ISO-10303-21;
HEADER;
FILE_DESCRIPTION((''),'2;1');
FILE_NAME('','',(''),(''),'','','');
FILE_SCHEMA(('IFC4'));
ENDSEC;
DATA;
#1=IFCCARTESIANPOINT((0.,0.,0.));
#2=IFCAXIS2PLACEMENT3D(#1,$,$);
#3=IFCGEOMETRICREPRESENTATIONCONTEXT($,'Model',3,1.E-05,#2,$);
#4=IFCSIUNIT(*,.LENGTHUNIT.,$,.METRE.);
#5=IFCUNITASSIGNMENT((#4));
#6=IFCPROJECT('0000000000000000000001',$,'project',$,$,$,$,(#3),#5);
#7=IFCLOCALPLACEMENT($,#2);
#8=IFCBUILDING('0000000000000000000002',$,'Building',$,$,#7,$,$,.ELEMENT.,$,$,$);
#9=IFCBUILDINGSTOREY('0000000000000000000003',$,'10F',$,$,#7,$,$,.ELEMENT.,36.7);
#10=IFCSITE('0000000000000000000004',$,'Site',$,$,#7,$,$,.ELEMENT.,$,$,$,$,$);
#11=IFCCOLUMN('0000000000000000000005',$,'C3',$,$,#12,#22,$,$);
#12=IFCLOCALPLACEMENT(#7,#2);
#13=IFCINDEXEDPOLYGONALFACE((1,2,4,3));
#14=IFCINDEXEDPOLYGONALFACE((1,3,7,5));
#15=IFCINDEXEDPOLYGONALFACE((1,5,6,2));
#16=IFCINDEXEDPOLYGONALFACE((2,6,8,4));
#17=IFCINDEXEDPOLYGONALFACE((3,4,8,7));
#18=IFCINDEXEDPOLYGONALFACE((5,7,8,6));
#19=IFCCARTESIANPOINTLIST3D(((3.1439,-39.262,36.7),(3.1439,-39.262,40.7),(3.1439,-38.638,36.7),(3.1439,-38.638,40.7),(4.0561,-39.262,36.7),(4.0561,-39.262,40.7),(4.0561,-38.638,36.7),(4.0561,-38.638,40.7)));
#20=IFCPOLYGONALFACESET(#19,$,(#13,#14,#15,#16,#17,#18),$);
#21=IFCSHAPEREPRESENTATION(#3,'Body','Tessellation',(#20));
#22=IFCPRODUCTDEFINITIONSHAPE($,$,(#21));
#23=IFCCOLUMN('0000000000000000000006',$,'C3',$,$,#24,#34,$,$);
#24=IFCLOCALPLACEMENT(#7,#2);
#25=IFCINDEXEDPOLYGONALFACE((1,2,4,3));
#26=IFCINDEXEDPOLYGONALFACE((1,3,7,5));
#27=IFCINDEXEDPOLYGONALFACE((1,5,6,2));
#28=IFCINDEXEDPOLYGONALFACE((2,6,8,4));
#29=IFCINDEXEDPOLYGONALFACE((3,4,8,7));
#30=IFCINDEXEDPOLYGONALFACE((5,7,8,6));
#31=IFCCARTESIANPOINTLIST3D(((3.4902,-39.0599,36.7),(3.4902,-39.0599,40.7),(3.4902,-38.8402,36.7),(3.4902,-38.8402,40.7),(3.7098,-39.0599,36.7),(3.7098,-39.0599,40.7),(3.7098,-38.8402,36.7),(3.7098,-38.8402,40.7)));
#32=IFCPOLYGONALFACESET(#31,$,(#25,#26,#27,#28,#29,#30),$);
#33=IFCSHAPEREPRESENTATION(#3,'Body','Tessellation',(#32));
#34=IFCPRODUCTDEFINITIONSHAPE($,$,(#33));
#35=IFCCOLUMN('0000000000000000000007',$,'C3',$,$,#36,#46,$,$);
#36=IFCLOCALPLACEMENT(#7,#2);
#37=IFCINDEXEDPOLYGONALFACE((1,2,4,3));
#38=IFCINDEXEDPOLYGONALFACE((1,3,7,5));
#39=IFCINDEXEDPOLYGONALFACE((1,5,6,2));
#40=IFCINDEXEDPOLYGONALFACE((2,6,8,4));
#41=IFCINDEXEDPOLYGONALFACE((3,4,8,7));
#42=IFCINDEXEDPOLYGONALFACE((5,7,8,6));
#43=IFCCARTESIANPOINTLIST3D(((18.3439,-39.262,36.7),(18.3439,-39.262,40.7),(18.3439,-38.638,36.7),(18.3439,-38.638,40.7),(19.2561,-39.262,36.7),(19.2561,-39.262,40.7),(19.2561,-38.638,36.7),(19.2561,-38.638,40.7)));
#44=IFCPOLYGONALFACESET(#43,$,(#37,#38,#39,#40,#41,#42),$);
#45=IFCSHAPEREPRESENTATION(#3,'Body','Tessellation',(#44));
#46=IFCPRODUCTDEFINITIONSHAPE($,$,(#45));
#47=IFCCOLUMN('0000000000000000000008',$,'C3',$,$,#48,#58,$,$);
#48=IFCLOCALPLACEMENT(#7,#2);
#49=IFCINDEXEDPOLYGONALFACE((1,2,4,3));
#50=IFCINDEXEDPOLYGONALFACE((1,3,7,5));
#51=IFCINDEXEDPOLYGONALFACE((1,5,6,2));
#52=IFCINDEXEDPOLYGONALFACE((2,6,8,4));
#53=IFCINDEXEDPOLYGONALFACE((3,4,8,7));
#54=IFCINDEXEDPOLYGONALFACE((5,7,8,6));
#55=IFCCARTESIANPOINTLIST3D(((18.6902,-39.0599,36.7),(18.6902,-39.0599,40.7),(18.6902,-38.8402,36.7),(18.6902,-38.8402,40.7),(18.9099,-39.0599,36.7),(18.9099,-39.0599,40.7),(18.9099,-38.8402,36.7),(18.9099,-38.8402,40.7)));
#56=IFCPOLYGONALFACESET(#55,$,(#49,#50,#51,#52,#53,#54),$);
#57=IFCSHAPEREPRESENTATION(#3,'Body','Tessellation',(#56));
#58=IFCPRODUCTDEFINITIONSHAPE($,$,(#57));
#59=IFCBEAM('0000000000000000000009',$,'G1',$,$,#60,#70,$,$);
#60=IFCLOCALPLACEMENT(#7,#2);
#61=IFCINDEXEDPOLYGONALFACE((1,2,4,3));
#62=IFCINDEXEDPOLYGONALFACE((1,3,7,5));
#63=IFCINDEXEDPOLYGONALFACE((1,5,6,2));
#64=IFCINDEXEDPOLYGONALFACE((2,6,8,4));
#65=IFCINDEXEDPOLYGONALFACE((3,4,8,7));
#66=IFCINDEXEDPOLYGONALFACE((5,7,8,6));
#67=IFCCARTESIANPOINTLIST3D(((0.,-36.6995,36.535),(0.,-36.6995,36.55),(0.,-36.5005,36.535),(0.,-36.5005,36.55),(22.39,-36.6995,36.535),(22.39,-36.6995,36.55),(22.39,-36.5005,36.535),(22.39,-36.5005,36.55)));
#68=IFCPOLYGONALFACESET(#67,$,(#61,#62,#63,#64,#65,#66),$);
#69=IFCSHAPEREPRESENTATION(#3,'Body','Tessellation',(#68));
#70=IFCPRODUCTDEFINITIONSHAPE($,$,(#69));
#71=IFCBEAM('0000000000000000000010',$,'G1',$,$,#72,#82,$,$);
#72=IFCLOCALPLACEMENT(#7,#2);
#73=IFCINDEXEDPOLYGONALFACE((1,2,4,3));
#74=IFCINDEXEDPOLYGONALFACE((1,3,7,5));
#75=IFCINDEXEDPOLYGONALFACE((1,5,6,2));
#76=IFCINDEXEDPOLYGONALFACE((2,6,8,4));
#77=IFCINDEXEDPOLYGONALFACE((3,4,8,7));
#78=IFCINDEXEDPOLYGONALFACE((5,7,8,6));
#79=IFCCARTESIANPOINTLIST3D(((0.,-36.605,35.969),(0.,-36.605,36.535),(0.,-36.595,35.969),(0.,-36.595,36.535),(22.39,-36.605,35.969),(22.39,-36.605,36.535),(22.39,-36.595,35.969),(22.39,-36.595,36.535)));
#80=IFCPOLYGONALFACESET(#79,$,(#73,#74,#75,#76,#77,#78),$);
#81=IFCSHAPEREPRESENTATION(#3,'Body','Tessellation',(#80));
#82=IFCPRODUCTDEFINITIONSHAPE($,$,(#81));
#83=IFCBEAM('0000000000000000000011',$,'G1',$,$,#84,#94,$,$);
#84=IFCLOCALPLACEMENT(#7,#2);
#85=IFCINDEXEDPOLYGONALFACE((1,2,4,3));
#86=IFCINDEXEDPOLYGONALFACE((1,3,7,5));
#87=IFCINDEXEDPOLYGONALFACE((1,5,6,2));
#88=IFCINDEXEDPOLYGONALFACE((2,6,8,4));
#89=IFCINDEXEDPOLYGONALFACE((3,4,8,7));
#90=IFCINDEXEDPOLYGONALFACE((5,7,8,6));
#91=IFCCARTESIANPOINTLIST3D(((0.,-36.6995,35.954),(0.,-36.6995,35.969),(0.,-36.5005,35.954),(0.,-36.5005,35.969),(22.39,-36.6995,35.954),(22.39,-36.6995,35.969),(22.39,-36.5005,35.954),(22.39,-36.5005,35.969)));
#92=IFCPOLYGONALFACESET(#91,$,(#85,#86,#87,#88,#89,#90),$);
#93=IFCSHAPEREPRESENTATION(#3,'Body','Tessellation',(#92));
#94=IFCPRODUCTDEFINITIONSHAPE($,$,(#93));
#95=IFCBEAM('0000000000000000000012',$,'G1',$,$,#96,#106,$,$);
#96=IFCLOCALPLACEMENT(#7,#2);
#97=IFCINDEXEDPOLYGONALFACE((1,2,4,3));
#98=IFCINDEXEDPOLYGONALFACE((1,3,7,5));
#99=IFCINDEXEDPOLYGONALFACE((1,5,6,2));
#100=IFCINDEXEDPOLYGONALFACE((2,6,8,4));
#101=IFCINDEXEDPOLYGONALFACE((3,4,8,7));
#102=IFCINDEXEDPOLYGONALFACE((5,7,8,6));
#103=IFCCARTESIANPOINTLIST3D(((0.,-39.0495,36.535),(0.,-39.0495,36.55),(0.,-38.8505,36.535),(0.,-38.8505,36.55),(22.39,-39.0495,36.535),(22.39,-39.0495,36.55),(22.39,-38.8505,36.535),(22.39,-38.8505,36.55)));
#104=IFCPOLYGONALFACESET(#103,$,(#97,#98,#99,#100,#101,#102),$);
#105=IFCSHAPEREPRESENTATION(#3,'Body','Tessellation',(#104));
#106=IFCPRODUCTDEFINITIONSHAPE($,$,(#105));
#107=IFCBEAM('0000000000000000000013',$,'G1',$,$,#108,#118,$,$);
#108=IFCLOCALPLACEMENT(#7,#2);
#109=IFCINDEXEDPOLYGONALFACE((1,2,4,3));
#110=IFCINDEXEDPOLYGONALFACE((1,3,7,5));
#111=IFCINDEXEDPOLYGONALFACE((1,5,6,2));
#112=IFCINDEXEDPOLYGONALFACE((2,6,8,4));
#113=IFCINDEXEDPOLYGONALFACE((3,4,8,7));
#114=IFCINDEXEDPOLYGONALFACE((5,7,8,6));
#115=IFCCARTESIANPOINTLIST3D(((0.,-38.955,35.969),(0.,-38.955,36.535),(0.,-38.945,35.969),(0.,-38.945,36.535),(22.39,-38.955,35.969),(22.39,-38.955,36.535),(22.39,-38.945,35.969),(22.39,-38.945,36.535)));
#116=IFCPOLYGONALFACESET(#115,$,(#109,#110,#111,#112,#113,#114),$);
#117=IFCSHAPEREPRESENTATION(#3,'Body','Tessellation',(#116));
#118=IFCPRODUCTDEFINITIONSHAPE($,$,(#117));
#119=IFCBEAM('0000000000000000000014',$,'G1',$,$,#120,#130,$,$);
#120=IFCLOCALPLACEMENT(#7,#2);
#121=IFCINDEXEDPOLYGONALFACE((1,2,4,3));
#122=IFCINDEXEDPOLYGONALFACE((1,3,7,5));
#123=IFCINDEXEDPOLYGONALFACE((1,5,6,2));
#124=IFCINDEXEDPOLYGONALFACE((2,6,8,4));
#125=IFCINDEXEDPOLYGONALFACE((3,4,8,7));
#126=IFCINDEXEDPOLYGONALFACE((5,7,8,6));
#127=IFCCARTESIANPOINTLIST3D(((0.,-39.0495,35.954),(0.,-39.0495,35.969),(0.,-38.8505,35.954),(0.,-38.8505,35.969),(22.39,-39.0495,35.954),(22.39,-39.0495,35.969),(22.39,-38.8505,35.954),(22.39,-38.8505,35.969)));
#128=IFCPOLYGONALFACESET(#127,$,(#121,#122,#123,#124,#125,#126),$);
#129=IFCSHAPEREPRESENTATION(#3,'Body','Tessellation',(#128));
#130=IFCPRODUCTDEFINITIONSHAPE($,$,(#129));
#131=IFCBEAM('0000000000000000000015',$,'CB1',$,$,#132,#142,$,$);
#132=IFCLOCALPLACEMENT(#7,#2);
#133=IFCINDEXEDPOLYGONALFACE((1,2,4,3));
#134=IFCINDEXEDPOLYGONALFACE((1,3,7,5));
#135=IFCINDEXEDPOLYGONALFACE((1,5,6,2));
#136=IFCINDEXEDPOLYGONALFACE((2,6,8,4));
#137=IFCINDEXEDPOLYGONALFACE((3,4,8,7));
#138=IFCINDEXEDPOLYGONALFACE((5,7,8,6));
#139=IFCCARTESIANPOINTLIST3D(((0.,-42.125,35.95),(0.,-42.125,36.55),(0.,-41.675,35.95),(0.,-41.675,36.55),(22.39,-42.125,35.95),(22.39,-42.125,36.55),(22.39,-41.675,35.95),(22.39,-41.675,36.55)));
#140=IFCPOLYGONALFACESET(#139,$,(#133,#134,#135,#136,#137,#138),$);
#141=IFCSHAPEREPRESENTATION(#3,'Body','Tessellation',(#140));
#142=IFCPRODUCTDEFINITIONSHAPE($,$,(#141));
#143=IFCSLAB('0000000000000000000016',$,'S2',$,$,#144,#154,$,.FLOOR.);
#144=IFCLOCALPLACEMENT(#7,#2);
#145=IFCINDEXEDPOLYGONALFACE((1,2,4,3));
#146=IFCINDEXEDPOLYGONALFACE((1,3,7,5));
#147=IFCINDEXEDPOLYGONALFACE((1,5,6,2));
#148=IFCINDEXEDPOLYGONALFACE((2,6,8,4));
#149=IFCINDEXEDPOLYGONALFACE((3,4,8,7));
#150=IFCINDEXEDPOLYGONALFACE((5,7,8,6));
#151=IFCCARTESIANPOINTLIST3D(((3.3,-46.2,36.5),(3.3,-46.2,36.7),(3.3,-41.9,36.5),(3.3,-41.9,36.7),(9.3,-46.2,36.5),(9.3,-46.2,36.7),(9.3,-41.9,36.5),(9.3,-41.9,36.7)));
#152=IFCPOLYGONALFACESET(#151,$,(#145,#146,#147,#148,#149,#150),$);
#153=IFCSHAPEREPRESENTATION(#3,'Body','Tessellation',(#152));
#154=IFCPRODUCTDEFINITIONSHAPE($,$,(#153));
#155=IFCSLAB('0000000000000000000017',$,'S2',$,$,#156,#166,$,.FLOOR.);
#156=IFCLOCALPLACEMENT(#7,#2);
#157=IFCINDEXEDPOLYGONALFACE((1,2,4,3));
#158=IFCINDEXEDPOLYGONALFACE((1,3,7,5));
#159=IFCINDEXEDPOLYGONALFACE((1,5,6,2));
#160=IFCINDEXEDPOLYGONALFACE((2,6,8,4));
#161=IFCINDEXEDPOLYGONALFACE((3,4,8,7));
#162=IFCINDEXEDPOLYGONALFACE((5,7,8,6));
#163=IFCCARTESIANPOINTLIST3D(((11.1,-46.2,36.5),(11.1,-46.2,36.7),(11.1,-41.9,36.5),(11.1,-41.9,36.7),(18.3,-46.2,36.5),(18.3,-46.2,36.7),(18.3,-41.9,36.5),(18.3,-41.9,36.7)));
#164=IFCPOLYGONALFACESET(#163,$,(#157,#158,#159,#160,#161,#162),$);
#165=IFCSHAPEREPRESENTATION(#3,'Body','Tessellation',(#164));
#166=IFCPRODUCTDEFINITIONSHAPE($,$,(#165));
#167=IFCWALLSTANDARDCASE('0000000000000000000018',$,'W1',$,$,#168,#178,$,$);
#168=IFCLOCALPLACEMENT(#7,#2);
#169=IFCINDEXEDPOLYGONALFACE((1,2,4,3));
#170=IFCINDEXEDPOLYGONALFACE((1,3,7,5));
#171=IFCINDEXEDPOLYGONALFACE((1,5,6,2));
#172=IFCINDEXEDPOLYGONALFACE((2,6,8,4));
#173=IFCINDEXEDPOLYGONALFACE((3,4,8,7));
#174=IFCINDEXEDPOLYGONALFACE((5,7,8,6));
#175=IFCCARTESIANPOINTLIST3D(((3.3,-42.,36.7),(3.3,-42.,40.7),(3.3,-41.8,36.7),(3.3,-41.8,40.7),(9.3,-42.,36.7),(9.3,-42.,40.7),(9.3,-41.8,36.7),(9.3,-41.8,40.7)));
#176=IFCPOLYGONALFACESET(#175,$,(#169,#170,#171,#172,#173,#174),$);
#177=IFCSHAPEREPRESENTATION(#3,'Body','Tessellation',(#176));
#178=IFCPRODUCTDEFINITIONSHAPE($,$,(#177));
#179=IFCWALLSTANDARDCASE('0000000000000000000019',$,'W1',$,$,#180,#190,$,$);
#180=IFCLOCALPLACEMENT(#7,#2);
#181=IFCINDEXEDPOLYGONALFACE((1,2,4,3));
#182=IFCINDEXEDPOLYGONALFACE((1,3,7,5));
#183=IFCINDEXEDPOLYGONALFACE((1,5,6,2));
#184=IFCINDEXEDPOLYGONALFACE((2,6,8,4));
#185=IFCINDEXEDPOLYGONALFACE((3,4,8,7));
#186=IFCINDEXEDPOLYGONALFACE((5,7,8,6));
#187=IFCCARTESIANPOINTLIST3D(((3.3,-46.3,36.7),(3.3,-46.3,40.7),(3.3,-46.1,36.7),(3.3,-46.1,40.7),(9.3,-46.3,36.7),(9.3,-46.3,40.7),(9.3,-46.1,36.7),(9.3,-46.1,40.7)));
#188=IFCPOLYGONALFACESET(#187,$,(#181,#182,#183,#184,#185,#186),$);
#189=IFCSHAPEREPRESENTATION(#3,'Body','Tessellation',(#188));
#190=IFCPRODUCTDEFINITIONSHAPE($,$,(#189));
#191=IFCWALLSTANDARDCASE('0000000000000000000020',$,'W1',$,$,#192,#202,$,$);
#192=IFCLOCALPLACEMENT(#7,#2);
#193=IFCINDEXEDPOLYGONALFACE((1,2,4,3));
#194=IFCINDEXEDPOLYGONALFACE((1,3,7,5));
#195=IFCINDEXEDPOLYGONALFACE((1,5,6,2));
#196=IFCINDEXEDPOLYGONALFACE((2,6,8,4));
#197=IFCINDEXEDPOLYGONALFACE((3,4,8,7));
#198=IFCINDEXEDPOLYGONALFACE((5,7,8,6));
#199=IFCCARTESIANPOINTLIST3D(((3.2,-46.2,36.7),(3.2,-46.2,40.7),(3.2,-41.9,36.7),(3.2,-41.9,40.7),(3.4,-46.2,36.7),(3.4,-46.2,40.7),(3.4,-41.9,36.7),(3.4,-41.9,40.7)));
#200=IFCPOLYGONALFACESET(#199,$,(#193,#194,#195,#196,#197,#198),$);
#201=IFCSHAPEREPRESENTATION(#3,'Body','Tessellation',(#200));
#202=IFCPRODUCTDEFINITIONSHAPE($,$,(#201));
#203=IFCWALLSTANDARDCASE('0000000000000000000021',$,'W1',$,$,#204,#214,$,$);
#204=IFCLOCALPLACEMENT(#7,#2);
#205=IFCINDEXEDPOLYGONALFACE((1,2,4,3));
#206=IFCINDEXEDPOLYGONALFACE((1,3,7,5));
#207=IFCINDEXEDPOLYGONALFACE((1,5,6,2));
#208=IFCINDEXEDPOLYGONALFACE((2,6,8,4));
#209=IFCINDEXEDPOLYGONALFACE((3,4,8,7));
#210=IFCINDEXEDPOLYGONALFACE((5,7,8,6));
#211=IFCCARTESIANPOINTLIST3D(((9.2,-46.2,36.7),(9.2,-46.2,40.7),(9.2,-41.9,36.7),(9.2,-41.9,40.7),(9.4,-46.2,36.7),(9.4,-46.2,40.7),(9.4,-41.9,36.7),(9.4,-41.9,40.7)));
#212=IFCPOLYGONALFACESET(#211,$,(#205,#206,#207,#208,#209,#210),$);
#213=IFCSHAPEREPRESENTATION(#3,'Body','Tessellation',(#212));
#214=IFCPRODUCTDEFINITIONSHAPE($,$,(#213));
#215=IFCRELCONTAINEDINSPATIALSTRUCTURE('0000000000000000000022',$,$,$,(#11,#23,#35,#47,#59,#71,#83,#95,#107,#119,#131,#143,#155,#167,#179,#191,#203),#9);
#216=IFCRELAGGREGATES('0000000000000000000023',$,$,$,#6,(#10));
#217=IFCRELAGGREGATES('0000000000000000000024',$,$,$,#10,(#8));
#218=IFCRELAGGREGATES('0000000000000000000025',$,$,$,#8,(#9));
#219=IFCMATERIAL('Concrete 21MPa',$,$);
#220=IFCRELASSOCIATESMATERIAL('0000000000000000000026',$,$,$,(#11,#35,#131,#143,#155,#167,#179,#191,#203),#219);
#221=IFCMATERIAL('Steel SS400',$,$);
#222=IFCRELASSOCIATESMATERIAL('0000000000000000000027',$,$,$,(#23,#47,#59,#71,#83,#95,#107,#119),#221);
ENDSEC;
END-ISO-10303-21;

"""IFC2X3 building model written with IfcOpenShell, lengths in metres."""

from ifc_helpers import new_model, si_unit, frame, origin, origin_2d, place, context, project, spatial, rectangle, extrude, material, element, save


model = new_model("IFC2X3")

# Units and contexts
model_context = context("Model", 3, precision=1e-05, world=origin())
ifc_project = project(units=[si_unit("LENGTHUNIT", "METRE")], contexts=[model_context])

# Site, building, storey
placement = place(None, origin())
site = spatial("IfcSite", under=ifc_project, at=placement, Name="Site", CompositionType="ELEMENT")
building = spatial("IfcBuilding", under=site, at=placement, Name="Building", CompositionType="ELEMENT")
storey = spatial("IfcBuildingStorey", under=building, at=placement, Name="10F", CompositionType="ELEMENT", Elevation=36.7)

# Columns
ifc_material_1 = material(Name="Concrete 21MPa")
column_1_placement = place(None, frame((3.6, -38.95, 36.7)))
element("IfcColumn", 1, at=column_1_placement, inside=storey, material=ifc_material_1, Name="C3", context=model_context, shape_type="SweptSolid", body=[
    extrude(rectangle(XDim=0.9121, YDim=0.6241, at=origin_2d()), origin(), (0.0, 0.0, 1.0), 4.0),
])
ifc_material_2 = material(Name="Steel SS400")
column_2_placement = place(None, frame((3.6, -38.95, 36.7)))
element("IfcColumn", 2, at=column_2_placement, inside=storey, material=ifc_material_2, Name="C3", context=model_context, shape_type="SweptSolid", body=[
    extrude(rectangle(XDim=0.2197, YDim=0.2197, at=origin_2d()), origin(), (0.0, 0.0, 1.0), 4.0),
])
column_3_placement = place(None, frame((18.8, -38.95, 36.7)))
element("IfcColumn", 3, at=column_3_placement, inside=storey, material=ifc_material_1, Name="C3", context=model_context, shape_type="SweptSolid", body=[
    extrude(rectangle(XDim=0.9121, YDim=0.6241, at=origin_2d()), origin(), (0.0, 0.0, 1.0), 4.0),
])
column_4_placement = place(None, frame((18.8, -38.95, 36.7)))
element("IfcColumn", 4, at=column_4_placement, inside=storey, material=ifc_material_2, Name="C3", context=model_context, shape_type="SweptSolid", body=[
    extrude(rectangle(XDim=0.2197, YDim=0.2197, at=origin_2d()), origin(), (0.0, 0.0, 1.0), 4.0),
])

# Beams
beam_1_placement = place(None, frame((11.195, -36.6, 36.535)))
element("IfcBeam", 5, at=beam_1_placement, inside=storey, material=ifc_material_2, Name="G1", context=model_context, shape_type="SweptSolid", body=[
    extrude(rectangle(XDim=22.39, YDim=0.199, at=origin_2d()), origin(), (0.0, 0.0, 1.0), 0.015),
])
beam_2_placement = place(None, frame((11.195, -36.6, 35.969)))
element("IfcBeam", 6, at=beam_2_placement, inside=storey, material=ifc_material_2, Name="G1", context=model_context, shape_type="SweptSolid", body=[
    extrude(rectangle(XDim=22.39, YDim=0.01, at=origin_2d()), origin(), (0.0, 0.0, 1.0), 0.566),
])
for number, where, name in (
    (7, (11.195, -36.6, 35.954), "G1"),
    (8, (11.195, -38.95, 36.535), "G1"),
):
    element("IfcBeam", number, at=place(None, frame(where)), inside=storey, material=ifc_material_2, Name=name, context=model_context, shape_type="SweptSolid", body=[
        extrude(rectangle(XDim=22.39, YDim=0.199, at=origin_2d()), origin(), (0.0, 0.0, 1.0), 0.015),
    ])
beam_3_placement = place(None, frame((11.195, -38.95, 35.969)))
element("IfcBeam", 9, at=beam_3_placement, inside=storey, material=ifc_material_2, Name="G1", context=model_context, shape_type="SweptSolid", body=[
    extrude(rectangle(XDim=22.39, YDim=0.01, at=origin_2d()), origin(), (0.0, 0.0, 1.0), 0.566),
])
beam_4_placement = place(None, frame((11.195, -38.95, 35.954)))
element("IfcBeam", 10, at=beam_4_placement, inside=storey, material=ifc_material_2, Name="G1", context=model_context, shape_type="SweptSolid", body=[
    extrude(rectangle(XDim=22.39, YDim=0.199, at=origin_2d()), origin(), (0.0, 0.0, 1.0), 0.015),
])
beam_5_placement = place(None, frame((11.195, -41.9, 35.95)))
element("IfcBeam", 11, at=beam_5_placement, inside=storey, material=ifc_material_1, Name="CB1", context=model_context, shape_type="SweptSolid", body=[
    extrude(rectangle(XDim=22.39, YDim=0.45, at=origin_2d()), origin(), (0.0, 0.0, 1.0), 0.6),
])

# Slabs
slab_1_placement = place(None, frame((6.3, -44.05, 36.5)))
element("IfcSlab", 12, at=slab_1_placement, inside=storey, material=ifc_material_1, Name="S2", PredefinedType="FLOOR", context=model_context, shape_type="SweptSolid", body=[
    extrude(rectangle(XDim=6.0, YDim=4.3, at=origin_2d()), origin(), (0.0, 0.0, 1.0), 0.2),
])
slab_2_placement = place(None, frame((14.7, -44.05, 36.5)))
element("IfcSlab", 13, at=slab_2_placement, inside=storey, material=ifc_material_1, Name="S2", PredefinedType="FLOOR", context=model_context, shape_type="SweptSolid", body=[
    extrude(rectangle(XDim=7.2, YDim=4.3, at=origin_2d()), origin(), (0.0, 0.0, 1.0), 0.2),
])

# Walls
for number, where, name in (
    (14, (6.3, -41.9, 36.7), "W1"),
    (15, (6.3, -46.2, 36.7), "W1"),
):
    element("IfcWallStandardCase", number, at=place(None, frame(where)), inside=storey, material=ifc_material_1, Name=name, context=model_context, shape_type="SweptSolid", body=[
        extrude(rectangle(XDim=6.0, YDim=0.2, at=origin_2d()), origin(), (0.0, 0.0, 1.0), 4.0),
    ])
for number, where, name in (
    (16, (3.3, -44.05, 36.7), "W1"),
    (17, (9.3, -44.05, 36.7), "W1"),
):
    element("IfcWallStandardCase", number, at=place(None, frame(where)), inside=storey, material=ifc_material_1, Name=name, context=model_context, shape_type="SweptSolid", body=[
        extrude(rectangle(XDim=0.2, YDim=4.3, at=origin_2d()), origin(), (0.0, 0.0, 1.0), 4.0),
    ])

save(model, "model.ifc")
